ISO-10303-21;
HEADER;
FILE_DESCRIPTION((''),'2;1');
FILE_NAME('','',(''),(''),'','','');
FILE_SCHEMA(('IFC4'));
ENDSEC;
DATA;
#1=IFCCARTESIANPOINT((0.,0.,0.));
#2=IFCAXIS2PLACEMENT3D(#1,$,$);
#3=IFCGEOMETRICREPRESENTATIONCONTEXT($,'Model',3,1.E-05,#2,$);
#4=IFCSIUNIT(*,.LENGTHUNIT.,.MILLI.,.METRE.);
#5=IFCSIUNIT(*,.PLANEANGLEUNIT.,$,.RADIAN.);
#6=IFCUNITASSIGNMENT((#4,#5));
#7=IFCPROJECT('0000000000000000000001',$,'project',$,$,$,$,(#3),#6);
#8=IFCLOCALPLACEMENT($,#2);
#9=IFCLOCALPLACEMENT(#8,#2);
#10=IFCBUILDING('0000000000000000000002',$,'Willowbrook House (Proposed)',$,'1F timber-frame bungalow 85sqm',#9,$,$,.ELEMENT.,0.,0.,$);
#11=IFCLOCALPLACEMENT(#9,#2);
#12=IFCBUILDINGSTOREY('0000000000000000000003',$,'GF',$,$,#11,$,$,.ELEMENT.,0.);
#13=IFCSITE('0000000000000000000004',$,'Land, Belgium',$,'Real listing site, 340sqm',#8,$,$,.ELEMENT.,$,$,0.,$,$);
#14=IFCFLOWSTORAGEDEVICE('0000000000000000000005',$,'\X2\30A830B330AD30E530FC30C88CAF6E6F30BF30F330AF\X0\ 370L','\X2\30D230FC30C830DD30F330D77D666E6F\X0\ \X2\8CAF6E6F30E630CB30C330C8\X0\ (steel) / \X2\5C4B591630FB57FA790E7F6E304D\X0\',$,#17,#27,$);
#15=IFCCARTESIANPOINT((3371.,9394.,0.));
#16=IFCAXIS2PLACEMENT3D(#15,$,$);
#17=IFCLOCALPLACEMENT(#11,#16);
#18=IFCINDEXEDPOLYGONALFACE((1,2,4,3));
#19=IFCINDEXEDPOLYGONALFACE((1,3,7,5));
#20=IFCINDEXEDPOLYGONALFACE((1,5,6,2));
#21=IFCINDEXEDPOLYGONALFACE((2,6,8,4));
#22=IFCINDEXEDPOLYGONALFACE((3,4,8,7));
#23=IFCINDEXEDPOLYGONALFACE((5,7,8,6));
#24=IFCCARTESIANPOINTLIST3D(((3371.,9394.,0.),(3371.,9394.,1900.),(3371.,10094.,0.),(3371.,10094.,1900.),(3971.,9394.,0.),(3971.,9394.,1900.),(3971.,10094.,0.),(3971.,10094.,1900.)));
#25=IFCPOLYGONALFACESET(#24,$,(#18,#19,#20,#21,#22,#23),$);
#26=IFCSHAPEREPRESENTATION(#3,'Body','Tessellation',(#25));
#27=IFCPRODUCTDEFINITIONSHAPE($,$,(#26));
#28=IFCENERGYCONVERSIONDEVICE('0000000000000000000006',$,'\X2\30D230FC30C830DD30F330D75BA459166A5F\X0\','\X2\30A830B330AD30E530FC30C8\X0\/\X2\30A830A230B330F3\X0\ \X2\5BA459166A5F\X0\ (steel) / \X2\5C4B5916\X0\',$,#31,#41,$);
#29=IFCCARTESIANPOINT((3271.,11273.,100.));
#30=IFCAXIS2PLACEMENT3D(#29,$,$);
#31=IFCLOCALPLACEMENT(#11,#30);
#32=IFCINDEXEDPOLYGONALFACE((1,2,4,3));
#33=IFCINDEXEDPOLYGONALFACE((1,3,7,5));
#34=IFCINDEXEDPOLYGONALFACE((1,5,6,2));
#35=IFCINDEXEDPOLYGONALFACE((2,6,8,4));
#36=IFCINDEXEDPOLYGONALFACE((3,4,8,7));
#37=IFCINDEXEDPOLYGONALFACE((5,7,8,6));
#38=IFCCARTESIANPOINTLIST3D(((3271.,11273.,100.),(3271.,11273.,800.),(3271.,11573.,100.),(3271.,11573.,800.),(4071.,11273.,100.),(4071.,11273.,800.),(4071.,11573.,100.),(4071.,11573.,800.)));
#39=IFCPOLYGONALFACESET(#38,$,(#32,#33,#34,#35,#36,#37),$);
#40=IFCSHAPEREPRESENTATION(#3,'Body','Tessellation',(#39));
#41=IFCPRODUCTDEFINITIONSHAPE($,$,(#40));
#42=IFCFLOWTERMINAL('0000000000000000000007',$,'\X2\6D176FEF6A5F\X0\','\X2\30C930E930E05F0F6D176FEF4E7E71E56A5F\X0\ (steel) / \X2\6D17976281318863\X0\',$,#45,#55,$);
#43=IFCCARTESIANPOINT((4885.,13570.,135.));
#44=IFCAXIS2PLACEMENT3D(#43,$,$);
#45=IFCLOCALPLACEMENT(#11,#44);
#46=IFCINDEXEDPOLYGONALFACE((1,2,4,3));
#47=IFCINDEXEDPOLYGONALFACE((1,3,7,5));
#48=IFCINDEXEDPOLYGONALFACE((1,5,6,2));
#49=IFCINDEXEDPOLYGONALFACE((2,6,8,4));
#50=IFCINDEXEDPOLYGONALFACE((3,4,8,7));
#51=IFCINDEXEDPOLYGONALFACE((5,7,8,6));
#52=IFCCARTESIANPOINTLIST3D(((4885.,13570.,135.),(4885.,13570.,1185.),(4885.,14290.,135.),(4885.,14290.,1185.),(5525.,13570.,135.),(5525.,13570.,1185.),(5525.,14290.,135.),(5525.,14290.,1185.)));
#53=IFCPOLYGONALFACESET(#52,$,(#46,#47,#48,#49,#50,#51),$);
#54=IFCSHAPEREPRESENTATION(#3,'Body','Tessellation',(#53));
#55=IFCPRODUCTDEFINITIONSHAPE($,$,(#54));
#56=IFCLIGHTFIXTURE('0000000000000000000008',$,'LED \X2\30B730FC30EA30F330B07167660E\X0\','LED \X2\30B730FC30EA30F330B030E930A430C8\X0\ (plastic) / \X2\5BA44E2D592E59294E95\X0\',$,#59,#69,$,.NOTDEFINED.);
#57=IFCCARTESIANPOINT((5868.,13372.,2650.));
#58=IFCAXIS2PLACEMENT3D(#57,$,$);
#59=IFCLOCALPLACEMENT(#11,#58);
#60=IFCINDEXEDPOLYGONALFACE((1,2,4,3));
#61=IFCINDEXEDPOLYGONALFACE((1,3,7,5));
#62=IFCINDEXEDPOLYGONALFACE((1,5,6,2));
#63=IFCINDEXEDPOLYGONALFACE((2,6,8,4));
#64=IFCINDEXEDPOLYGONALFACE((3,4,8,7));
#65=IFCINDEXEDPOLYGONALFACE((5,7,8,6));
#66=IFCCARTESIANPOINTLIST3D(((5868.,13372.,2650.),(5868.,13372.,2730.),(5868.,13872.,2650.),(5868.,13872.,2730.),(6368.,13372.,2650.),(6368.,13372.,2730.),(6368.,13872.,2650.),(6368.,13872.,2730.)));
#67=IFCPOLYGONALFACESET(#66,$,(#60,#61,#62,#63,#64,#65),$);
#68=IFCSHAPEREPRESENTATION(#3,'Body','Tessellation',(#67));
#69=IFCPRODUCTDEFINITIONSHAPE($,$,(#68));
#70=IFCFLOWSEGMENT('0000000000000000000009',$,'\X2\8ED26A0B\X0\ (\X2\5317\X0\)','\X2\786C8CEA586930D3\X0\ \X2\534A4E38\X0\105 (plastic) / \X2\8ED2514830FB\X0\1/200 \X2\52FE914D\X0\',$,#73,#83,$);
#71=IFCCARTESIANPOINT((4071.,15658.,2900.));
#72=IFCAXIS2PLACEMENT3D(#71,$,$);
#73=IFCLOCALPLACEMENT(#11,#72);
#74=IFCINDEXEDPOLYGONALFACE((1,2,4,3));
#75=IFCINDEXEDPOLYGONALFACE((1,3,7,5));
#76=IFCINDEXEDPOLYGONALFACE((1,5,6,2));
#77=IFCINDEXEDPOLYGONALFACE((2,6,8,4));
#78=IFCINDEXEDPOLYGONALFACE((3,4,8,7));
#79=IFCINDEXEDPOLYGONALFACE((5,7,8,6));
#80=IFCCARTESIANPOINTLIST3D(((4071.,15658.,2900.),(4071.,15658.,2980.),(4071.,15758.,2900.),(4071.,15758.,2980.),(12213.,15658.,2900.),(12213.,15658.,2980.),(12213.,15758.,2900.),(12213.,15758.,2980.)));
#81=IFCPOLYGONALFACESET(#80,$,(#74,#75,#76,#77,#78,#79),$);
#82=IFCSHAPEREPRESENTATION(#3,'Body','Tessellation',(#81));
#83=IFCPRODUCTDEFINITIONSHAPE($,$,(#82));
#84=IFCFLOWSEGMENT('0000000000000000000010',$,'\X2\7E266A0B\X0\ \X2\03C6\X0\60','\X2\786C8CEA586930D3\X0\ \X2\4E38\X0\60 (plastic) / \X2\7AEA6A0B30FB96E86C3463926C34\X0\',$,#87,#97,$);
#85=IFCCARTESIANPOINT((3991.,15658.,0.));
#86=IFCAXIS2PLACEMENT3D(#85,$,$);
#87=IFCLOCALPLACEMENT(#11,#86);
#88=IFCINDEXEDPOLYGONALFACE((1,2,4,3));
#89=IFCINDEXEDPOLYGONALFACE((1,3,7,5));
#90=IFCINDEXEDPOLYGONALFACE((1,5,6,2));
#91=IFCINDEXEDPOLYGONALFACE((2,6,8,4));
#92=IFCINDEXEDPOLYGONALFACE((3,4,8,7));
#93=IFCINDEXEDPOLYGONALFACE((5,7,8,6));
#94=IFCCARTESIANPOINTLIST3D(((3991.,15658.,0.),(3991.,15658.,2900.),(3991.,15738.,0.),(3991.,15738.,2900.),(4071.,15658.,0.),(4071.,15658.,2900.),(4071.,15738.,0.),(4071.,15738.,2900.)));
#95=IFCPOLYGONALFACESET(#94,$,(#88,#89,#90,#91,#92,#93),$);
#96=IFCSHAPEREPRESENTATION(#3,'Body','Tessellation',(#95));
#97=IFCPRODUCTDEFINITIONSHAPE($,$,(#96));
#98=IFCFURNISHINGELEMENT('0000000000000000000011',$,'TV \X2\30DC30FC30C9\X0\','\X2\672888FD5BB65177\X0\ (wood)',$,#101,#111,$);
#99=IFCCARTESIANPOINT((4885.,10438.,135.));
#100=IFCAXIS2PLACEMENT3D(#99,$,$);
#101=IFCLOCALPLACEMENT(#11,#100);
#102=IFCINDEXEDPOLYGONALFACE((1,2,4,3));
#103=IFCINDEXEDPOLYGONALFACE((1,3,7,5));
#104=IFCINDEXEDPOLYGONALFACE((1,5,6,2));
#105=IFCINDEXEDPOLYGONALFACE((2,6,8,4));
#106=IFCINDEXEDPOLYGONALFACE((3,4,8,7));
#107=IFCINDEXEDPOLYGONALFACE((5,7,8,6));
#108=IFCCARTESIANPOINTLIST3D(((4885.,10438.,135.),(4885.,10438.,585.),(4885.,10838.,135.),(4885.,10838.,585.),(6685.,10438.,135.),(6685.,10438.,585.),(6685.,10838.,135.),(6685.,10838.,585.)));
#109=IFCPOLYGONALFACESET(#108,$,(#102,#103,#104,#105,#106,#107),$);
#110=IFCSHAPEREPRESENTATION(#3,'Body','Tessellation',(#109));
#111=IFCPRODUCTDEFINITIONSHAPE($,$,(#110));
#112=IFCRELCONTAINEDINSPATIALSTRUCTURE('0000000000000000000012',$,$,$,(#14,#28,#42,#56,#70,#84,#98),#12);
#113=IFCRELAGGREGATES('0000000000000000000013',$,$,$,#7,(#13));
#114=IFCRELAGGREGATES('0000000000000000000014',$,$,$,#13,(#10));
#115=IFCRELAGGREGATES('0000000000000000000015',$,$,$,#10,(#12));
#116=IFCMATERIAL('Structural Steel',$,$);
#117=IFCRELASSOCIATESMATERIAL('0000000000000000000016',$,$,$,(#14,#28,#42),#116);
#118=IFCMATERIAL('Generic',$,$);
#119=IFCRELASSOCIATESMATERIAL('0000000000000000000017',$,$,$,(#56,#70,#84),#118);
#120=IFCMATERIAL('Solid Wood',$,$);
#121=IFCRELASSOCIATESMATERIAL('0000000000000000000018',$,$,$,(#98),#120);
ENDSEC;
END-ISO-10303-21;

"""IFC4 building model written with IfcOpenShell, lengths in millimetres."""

from ifc_helpers import new_model, si_unit, frame, frame_2d, origin, place, context, project, spatial, rectangle, extrude, material, element, save


model = new_model("IFC4")

# Units and contexts
model_context = context("Model", 3, precision=1e-05, world=origin())
ifc_project = project(units=[si_unit("LENGTHUNIT", "METRE", prefix="MILLI"), si_unit("PLANEANGLEUNIT", "RADIAN")], contexts=[model_context])

# Site, building, storey
site_placement = place(None, origin())
site = spatial("IfcSite", under=ifc_project, at=site_placement, Name="Land, Belgium", ObjectType="Real listing site, 340sqm", CompositionType="ELEMENT", RefElevation=0.0)
building_placement = place(site_placement, origin())
building = spatial("IfcBuilding", under=site, at=building_placement, Name="Willowbrook House (Proposed)", ObjectType="1F timber-frame bungalow 85sqm", CompositionType="ELEMENT", ElevationOfRefHeight=0.0, ElevationOfTerrain=0.0)
storey_placement = place(building_placement, origin())
storey = spatial("IfcBuildingStorey", under=building, at=storey_placement, Name="GF", CompositionType="ELEMENT", Elevation=0.0)

# Shared definitions
ifc_material_1 = material(Name="Solid Wood")

# Shared definitions
ifc_material_2 = material(Name="Structural Steel")

# Shared definitions
ifc_material_3 = material(Name="Generic")

# Flow storage device
flow_storage_device_placement = place(storey_placement, frame((3371.0, 9394.0, 0.0)))
element("IfcFlowStorageDevice", 1, at=flow_storage_device_placement, inside=storey, material=ifc_material_2, Name="エコキュート貯湯タンク 370L", Description="ヒートポンプ給湯 貯湯ユニット (steel) / 屋外・基礎置き", context=model_context, shape_type="SweptSolid", body=[
    extrude(rectangle(XDim=600.0, YDim=700.0, at=frame_2d((300.0, 350.0))), frame((3371.0, 9394.0, 0.0)), (0.0, 0.0, 1.0), 1900.0),
])

# Energy conversion device
energy_conversion_device_placement = place(storey_placement, frame((3271.0, 11273.0, 100.0)))
element("IfcEnergyConversionDevice", 2, at=energy_conversion_device_placement, inside=storey, material=ifc_material_2, Name="ヒートポンプ室外機", Description="エコキュート/エアコン 室外機 (steel) / 屋外", context=model_context, shape_type="SweptSolid", body=[
    extrude(rectangle(XDim=800.0, YDim=300.0, at=frame_2d((400.0, 150.0))), frame((3271.0, 11273.0, 100.0)), (0.0, 0.0, 1.0), 700.0),
])

# Flow terminal
flow_terminal_placement = place(storey_placement, frame((4885.0, 13570.0, 135.0)))
element("IfcFlowTerminal", 3, at=flow_terminal_placement, inside=storey, material=ifc_material_2, Name="洗濯機", Description="ドラム式洗濯乾燥機 (steel) / 洗面脱衣", context=model_context, shape_type="SweptSolid", body=[
    extrude(rectangle(XDim=640.0, YDim=720.0, at=frame_2d((320.0, 360.0))), frame((4885.0, 13570.0, 135.0)), (0.0, 0.0, 1.0), 1050.0),
])

# Light fixture
light_fixture_placement = place(storey_placement, frame((5868.0, 13372.0, 2650.0)))
element("IfcLightFixture", 4, at=light_fixture_placement, inside=storey, material=ifc_material_3, Name="LED シーリング照明", Description="LED シーリングライト (plastic) / 室中央天井", PredefinedType="NOTDEFINED", context=model_context, shape_type="SweptSolid", body=[
    extrude(rectangle(XDim=500.0, YDim=500.0, at=frame_2d((250.0, 250.0))), frame((5868.0, 13372.0, 2650.0)), (0.0, 0.0, 1.0), 80.0),
])

# Flow segments
flow_segment_1_placement = place(storey_placement, frame((4071.0, 15658.0, 2900.0)))
element("IfcFlowSegment", 5, at=flow_segment_1_placement, inside=storey, material=ifc_material_3, Name="軒樋 (北)", Description="硬質塩ビ 半丸105 (plastic) / 軒先・1/200 勾配", context=model_context, shape_type="SweptSolid", body=[
    extrude(rectangle(XDim=8142.0, YDim=100.0, at=frame_2d((4071.0, 50.0))), frame((4071.0, 15658.0, 2900.0)), (0.0, 0.0, 1.0), 80.0),
])
flow_segment_2_placement = place(storey_placement, frame((3991.0, 15658.0, 0.0)))
element("IfcFlowSegment", 6, at=flow_segment_2_placement, inside=storey, material=ifc_material_3, Name="縦樋 φ60", Description="硬質塩ビ 丸60 (plastic) / 竪樋・雨水排水", context=model_context, shape_type="SweptSolid", body=[
    extrude(rectangle(XDim=80.0, YDim=80.0, at=frame_2d((40.0, 40.0))), frame((3991.0, 15658.0, 0.0)), (0.0, 0.0, 1.0), 2900.0),
])

# Furnishing element
furnishing_placement = place(storey_placement, frame((4885.0, 10438.0, 135.0)))
element("IfcFurnishingElement", 7, at=furnishing_placement, inside=storey, material=ifc_material_1, Name="TV ボード", Description="木製家具 (wood)", context=model_context, shape_type="SweptSolid", body=[
    extrude(rectangle(XDim=1800.0, YDim=400.0, at=frame_2d((900.0, 200.0))), frame((4885.0, 10438.0, 135.0)), (0.0, 0.0, 1.0), 450.0),
])

save(model, "model.ifc")
